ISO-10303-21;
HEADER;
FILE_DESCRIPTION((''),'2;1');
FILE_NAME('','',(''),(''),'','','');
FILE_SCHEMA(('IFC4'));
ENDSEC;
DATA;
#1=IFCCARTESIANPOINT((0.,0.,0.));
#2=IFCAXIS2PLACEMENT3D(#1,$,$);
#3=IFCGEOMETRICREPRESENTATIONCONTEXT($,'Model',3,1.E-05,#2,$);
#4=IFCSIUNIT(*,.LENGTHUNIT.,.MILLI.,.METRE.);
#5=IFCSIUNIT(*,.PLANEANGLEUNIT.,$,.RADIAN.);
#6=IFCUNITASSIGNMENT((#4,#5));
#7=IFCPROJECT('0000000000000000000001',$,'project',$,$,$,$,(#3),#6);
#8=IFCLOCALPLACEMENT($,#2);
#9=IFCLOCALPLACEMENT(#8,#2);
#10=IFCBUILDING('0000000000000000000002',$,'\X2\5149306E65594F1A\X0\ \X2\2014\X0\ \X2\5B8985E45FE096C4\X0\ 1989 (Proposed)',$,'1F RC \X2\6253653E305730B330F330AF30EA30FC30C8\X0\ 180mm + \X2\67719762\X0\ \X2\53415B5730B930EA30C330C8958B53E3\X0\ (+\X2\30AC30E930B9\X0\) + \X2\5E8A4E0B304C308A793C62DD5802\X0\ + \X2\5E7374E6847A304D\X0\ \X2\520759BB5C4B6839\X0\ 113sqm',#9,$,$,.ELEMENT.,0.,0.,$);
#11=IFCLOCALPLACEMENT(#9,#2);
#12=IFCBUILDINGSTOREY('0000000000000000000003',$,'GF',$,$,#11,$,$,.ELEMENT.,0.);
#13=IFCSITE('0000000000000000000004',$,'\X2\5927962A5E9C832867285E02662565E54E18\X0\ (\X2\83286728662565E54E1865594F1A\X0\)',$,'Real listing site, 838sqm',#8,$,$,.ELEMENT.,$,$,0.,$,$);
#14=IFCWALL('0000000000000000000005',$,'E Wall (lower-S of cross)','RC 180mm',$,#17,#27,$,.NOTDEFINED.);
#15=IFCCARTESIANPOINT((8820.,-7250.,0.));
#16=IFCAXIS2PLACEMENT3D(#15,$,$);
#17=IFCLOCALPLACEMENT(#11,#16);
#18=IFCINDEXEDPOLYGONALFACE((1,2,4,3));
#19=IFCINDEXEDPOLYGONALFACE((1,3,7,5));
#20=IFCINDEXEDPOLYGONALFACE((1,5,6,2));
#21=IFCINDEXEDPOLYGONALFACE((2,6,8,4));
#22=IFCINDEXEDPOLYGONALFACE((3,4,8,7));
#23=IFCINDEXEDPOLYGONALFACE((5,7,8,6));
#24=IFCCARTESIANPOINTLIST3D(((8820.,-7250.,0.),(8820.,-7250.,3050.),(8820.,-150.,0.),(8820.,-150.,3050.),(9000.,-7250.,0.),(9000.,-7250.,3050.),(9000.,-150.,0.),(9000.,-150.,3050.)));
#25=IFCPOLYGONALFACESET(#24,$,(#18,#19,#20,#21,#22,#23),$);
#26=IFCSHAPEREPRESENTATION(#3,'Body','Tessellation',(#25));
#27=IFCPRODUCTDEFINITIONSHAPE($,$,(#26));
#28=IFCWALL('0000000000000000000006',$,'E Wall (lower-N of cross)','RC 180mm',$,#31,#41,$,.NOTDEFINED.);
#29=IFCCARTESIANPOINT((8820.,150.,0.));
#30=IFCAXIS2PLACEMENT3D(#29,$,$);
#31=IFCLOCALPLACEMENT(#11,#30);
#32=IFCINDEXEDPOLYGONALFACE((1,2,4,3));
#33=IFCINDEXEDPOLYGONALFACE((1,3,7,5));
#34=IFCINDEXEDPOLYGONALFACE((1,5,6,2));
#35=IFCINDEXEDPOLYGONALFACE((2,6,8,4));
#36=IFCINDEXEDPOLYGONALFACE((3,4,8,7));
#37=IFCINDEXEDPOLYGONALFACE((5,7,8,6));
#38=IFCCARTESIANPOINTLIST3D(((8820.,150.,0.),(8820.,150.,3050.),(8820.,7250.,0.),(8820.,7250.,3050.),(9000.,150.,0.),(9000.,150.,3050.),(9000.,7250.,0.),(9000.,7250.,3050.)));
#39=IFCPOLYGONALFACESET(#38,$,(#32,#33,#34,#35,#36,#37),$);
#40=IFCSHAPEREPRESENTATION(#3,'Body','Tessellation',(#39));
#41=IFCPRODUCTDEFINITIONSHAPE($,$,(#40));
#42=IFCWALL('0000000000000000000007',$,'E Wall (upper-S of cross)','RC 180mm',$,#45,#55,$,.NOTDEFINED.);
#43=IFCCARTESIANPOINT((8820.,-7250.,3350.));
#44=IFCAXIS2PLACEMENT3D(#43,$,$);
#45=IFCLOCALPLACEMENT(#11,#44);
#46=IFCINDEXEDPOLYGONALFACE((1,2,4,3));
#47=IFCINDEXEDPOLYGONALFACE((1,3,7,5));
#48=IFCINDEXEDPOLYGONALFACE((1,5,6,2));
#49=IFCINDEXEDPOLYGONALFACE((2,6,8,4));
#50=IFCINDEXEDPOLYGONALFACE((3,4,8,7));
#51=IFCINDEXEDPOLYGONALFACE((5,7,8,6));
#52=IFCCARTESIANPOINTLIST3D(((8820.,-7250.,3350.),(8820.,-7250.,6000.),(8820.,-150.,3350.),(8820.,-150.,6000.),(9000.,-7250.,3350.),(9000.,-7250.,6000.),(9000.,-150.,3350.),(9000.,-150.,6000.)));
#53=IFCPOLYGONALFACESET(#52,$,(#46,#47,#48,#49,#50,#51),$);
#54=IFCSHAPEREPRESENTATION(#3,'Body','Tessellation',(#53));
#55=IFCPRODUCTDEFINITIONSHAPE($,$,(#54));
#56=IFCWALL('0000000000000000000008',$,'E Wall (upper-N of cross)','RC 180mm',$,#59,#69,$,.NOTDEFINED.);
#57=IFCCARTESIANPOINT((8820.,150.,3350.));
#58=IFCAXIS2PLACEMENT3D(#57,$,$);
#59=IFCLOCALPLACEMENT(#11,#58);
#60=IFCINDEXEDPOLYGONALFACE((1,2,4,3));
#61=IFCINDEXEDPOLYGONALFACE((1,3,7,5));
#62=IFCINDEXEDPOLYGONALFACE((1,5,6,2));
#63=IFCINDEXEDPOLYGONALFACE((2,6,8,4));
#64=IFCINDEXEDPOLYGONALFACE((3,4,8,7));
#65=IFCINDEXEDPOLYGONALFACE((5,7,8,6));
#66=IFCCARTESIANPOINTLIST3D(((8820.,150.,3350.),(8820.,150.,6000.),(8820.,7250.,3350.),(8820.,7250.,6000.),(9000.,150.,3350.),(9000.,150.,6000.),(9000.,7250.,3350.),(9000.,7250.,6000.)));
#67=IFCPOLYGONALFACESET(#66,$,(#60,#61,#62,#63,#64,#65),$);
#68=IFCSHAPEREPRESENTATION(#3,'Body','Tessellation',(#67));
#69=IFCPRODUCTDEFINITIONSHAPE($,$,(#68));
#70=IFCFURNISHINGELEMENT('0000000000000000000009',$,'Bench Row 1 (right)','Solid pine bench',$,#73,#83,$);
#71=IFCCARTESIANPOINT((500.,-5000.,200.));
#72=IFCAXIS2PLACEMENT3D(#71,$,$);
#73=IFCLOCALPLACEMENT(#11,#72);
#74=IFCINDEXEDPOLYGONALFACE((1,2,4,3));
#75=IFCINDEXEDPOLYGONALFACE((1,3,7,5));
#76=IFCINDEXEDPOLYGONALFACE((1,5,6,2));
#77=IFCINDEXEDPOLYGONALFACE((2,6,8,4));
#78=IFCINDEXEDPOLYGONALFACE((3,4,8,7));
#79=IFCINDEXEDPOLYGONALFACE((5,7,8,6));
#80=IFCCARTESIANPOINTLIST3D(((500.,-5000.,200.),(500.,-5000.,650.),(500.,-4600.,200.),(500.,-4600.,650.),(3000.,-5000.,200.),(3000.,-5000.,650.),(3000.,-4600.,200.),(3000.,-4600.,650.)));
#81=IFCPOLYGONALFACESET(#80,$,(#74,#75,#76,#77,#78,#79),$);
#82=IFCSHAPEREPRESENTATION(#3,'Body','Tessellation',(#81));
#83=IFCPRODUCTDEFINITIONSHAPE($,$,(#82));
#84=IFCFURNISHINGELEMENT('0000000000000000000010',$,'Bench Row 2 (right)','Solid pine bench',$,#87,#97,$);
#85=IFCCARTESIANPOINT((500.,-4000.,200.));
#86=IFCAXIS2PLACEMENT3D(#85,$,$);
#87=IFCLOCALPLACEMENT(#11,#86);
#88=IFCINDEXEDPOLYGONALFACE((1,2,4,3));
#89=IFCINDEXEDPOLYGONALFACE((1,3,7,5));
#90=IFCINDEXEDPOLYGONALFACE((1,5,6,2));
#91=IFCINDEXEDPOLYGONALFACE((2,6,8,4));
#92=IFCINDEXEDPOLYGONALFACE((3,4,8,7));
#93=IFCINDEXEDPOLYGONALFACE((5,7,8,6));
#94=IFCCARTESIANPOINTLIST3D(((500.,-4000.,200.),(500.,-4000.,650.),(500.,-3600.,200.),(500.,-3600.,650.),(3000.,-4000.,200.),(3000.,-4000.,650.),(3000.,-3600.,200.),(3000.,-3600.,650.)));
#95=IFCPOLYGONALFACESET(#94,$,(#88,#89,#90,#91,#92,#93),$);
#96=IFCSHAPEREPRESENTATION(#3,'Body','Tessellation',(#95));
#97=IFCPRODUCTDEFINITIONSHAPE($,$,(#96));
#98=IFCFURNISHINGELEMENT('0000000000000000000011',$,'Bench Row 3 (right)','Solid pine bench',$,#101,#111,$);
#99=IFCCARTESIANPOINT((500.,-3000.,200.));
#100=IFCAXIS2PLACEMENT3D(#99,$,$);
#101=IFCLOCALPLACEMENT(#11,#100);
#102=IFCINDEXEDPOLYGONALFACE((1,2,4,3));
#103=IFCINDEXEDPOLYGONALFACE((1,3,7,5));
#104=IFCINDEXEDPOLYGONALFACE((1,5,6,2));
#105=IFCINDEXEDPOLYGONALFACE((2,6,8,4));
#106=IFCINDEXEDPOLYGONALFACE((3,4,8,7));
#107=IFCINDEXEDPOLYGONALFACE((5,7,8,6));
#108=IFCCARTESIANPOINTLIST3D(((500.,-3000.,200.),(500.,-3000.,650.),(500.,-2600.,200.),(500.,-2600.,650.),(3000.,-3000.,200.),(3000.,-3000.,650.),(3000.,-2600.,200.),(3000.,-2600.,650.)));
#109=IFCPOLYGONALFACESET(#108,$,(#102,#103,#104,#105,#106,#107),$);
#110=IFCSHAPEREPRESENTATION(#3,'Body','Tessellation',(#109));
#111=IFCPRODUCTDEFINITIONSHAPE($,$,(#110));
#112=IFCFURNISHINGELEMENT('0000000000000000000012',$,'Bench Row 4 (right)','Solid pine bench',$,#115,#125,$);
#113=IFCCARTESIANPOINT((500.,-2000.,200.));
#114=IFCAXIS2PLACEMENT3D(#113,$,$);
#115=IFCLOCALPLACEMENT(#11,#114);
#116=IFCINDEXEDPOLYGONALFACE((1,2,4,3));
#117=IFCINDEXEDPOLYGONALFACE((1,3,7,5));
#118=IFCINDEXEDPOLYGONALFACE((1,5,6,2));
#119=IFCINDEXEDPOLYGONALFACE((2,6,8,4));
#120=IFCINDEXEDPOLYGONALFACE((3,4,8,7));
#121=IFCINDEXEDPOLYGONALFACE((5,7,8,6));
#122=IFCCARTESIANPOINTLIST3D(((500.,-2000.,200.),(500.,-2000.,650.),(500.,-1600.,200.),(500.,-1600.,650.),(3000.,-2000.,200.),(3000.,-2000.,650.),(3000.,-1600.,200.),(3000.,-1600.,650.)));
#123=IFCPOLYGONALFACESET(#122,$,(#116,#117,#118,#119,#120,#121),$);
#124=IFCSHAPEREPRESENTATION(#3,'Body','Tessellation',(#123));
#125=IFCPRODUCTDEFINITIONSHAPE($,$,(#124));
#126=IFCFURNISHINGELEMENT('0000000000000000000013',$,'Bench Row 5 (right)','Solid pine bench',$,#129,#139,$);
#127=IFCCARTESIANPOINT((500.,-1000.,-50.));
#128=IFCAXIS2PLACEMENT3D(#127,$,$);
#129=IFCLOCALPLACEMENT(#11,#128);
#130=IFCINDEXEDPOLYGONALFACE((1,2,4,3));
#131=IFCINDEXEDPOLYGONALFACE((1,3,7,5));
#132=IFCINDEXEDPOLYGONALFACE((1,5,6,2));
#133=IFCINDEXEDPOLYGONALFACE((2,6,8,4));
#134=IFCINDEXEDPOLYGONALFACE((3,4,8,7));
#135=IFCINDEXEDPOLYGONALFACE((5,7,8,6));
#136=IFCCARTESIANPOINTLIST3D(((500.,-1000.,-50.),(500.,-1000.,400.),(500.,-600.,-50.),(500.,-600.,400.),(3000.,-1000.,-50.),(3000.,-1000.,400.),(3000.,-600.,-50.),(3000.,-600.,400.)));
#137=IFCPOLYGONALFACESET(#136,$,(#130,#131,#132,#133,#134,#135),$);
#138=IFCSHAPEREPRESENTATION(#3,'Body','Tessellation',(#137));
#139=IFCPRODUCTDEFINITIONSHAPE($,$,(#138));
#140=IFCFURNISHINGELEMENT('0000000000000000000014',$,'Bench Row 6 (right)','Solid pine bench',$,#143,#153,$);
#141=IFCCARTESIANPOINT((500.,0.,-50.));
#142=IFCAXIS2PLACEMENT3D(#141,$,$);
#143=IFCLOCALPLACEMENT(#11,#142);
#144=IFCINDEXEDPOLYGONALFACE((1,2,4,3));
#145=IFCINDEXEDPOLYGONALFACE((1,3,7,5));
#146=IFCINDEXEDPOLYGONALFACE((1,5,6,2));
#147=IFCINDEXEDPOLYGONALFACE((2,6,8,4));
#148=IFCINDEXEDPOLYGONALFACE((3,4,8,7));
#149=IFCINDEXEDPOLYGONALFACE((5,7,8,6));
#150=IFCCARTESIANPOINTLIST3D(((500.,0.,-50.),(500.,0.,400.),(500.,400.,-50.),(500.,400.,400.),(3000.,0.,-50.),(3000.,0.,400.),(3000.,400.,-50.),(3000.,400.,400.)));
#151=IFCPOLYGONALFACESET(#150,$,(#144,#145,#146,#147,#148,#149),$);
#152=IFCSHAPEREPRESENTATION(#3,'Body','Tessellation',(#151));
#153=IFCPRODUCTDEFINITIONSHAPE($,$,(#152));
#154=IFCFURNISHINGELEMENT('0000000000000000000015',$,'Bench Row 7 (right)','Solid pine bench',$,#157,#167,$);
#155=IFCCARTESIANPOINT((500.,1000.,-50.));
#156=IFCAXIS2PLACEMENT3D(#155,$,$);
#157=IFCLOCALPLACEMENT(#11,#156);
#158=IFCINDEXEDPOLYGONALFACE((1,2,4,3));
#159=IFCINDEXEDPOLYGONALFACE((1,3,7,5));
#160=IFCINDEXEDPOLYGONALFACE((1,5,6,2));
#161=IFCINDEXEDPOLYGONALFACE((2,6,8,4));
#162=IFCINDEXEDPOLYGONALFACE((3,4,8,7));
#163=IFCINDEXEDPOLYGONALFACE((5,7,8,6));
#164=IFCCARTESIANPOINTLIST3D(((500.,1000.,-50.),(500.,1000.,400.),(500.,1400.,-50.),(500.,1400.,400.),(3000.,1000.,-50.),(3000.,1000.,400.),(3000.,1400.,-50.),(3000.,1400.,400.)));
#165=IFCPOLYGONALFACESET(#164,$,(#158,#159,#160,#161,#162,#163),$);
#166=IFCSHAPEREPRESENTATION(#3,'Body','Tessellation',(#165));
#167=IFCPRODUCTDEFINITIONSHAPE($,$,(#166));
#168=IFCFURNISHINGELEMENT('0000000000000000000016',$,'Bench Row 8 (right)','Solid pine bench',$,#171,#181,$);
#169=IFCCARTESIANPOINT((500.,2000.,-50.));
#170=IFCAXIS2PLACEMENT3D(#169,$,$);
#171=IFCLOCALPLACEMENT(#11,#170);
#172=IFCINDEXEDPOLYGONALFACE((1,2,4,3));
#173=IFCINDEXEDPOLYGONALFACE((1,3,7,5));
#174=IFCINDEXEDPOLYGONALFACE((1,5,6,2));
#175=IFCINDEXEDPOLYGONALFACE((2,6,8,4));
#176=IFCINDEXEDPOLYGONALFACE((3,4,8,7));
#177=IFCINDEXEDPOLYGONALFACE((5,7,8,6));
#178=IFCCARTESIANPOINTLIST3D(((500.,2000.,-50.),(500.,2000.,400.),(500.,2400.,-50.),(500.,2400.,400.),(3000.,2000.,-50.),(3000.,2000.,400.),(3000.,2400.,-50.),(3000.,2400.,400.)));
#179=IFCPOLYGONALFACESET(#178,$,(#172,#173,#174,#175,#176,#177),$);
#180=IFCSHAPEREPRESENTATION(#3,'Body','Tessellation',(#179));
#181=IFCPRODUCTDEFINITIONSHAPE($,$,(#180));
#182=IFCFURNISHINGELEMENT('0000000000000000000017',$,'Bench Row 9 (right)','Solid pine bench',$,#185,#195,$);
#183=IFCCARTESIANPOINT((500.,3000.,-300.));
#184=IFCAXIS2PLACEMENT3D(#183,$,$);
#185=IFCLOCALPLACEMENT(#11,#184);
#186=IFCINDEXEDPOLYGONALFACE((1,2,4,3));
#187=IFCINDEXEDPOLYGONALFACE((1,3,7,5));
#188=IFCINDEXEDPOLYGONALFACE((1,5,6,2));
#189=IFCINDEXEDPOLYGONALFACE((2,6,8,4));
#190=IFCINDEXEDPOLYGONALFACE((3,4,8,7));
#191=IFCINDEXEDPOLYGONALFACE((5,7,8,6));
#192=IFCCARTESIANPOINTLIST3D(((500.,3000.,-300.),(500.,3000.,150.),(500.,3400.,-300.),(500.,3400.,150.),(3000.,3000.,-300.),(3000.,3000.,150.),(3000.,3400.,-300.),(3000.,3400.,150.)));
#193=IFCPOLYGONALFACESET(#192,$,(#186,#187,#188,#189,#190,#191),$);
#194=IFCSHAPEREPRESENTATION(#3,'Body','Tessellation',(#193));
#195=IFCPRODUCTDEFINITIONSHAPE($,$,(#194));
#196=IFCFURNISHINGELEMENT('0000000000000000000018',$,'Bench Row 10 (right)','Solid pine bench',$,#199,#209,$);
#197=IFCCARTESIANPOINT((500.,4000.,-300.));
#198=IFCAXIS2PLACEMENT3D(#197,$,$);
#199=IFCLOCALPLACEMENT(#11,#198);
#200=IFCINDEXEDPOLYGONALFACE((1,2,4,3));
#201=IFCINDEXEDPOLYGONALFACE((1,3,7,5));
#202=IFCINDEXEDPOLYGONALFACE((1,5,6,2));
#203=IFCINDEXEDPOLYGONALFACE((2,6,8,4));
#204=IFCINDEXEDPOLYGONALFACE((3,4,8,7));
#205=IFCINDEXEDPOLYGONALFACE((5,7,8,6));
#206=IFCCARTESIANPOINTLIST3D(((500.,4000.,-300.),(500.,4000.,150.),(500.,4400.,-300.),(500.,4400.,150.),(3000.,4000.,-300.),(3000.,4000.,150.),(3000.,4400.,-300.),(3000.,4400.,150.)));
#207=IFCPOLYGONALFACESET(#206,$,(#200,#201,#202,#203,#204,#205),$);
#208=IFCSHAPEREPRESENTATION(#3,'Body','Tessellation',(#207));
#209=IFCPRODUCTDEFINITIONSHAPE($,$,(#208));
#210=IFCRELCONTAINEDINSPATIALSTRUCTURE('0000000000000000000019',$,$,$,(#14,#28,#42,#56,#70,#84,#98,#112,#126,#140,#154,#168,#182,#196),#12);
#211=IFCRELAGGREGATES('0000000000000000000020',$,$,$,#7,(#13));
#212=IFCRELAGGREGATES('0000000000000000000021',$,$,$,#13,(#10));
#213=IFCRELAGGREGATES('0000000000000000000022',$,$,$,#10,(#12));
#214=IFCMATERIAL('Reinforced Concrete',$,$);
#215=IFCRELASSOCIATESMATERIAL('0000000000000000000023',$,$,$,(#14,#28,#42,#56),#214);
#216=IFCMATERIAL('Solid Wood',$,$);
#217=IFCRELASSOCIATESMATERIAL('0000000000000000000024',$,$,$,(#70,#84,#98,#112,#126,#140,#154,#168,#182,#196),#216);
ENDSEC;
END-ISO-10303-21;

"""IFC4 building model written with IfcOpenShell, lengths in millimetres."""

from ifc_helpers import new_model, si_unit, frame, frame_2d, origin, place, context, project, spatial, rectangle, extrude, material, element, save


model = new_model("IFC4")

# Units and contexts
model_context = context("Model", 3, precision=1e-05, world=origin())
ifc_project = project(units=[si_unit("LENGTHUNIT", "METRE", prefix="MILLI"), si_unit("PLANEANGLEUNIT", "RADIAN")], contexts=[model_context])

# Site, building, storey
site_placement = place(None, origin())
site = spatial("IfcSite", under=ifc_project, at=site_placement, Name="大阪府茨木市春日丘 (茨木春日丘教会)", ObjectType="Real listing site, 838sqm", CompositionType="ELEMENT", RefElevation=0.0)
building_placement = place(site_placement, origin())
building = spatial("IfcBuilding", under=site, at=building_placement, Name="光の教会 — 安藤忠雄 1989 (Proposed)", ObjectType="1F RC 打放しコンクリート 180mm + 東面 十字スリット開口 (+ガラス) + 床下がり礼拝堂 + 平瓦葺き 切妻屋根 113sqm", CompositionType="ELEMENT", ElevationOfRefHeight=0.0, ElevationOfTerrain=0.0)
storey_placement = place(building_placement, origin())
storey = spatial("IfcBuildingStorey", under=building, at=storey_placement, Name="GF", CompositionType="ELEMENT", Elevation=0.0)

# Walls
ifc_material_1 = material(Name="Reinforced Concrete")
wall_1_placement = place(storey_placement, frame((8820.0, -7250.0, 0.0)))
element("IfcWall", 1, at=wall_1_placement, inside=storey, material=ifc_material_1, Name="E Wall (lower-S of cross)", Description="RC 180mm", PredefinedType="NOTDEFINED", context=model_context, shape_type="SweptSolid", body=[
    extrude(rectangle(XDim=180.0, YDim=7100.0, at=frame_2d((90.0, 3550.0))), frame((8820.0, -7250.0, 0.0)), (0.0, 0.0, 1.0), 3050.0),
])
wall_2_placement = place(storey_placement, frame((8820.0, 150.0, 0.0)))
element("IfcWall", 2, at=wall_2_placement, inside=storey, material=ifc_material_1, Name="E Wall (lower-N of cross)", Description="RC 180mm", PredefinedType="NOTDEFINED", context=model_context, shape_type="SweptSolid", body=[
    extrude(rectangle(XDim=180.0, YDim=7100.0, at=frame_2d((90.0, 3550.0))), frame((8820.0, 150.0, 0.0)), (0.0, 0.0, 1.0), 3050.0),
])
wall_3_placement = place(storey_placement, frame((8820.0, -7250.0, 3350.0)))
element("IfcWall", 3, at=wall_3_placement, inside=storey, material=ifc_material_1, Name="E Wall (upper-S of cross)", Description="RC 180mm", PredefinedType="NOTDEFINED", context=model_context, shape_type="SweptSolid", body=[
    extrude(rectangle(XDim=180.0, YDim=7100.0, at=frame_2d((90.0, 3550.0))), frame((8820.0, -7250.0, 3350.0)), (0.0, 0.0, 1.0), 2650.0),
])
wall_4_placement = place(storey_placement, frame((8820.0, 150.0, 3350.0)))
element("IfcWall", 4, at=wall_4_placement, inside=storey, material=ifc_material_1, Name="E Wall (upper-N of cross)", Description="RC 180mm", PredefinedType="NOTDEFINED", context=model_context, shape_type="SweptSolid", body=[
    extrude(rectangle(XDim=180.0, YDim=7100.0, at=frame_2d((90.0, 3550.0))), frame((8820.0, 150.0, 3350.0)), (0.0, 0.0, 1.0), 2650.0),
])

# Furnishing elements
ifc_material_2 = material(Name="Solid Wood")
furnishing_1_placement = place(storey_placement, frame((500.0, -5000.0, 200.0)))
element("IfcFurnishingElement", 5, at=furnishing_1_placement, inside=storey, material=ifc_material_2, Name="Bench Row 1 (right)", Description="Solid pine bench", context=model_context, shape_type="SweptSolid", body=[
    extrude(rectangle(XDim=2500.0, YDim=400.0, at=frame_2d((1250.0, 200.0))), frame((500.0, -5000.0, 200.0)), (0.0, 0.0, 1.0), 450.0),
])
furnishing_2_placement = place(storey_placement, frame((500.0, -4000.0, 200.0)))
element("IfcFurnishingElement", 6, at=furnishing_2_placement, inside=storey, material=ifc_material_2, Name="Bench Row 2 (right)", Description="Solid pine bench", context=model_context, shape_type="SweptSolid", body=[
    extrude(rectangle(XDim=2500.0, YDim=400.0, at=frame_2d((1250.0, 200.0))), frame((500.0, -4000.0, 200.0)), (0.0, 0.0, 1.0), 450.0),
])
furnishing_3_placement = place(storey_placement, frame((500.0, -3000.0, 200.0)))
element("IfcFurnishingElement", 7, at=furnishing_3_placement, inside=storey, material=ifc_material_2, Name="Bench Row 3 (right)", Description="Solid pine bench", context=model_context, shape_type="SweptSolid", body=[
    extrude(rectangle(XDim=2500.0, YDim=400.0, at=frame_2d((1250.0, 200.0))), frame((500.0, -3000.0, 200.0)), (0.0, 0.0, 1.0), 450.0),
])
furnishing_4_placement = place(storey_placement, frame((500.0, -2000.0, 200.0)))
element("IfcFurnishingElement", 8, at=furnishing_4_placement, inside=storey, material=ifc_material_2, Name="Bench Row 4 (right)", Description="Solid pine bench", context=model_context, shape_type="SweptSolid", body=[
    extrude(rectangle(XDim=2500.0, YDim=400.0, at=frame_2d((1250.0, 200.0))), frame((500.0, -2000.0, 200.0)), (0.0, 0.0, 1.0), 450.0),
])
furnishing_5_placement = place(storey_placement, frame((500.0, -1000.0, -50.0)))
element("IfcFurnishingElement", 9, at=furnishing_5_placement, inside=storey, material=ifc_material_2, Name="Bench Row 5 (right)", Description="Solid pine bench", context=model_context, shape_type="SweptSolid", body=[
    extrude(rectangle(XDim=2500.0, YDim=400.0, at=frame_2d((1250.0, 200.0))), frame((500.0, -1000.0, -50.0)), (0.0, 0.0, 1.0), 450.0),
])
furnishing_6_placement = place(storey_placement, frame((500.0, 0.0, -50.0)))
element("IfcFurnishingElement", 10, at=furnishing_6_placement, inside=storey, material=ifc_material_2, Name="Bench Row 6 (right)", Description="Solid pine bench", context=model_context, shape_type="SweptSolid", body=[
    extrude(rectangle(XDim=2500.0, YDim=400.0, at=frame_2d((1250.0, 200.0))), frame((500.0, 0.0, -50.0)), (0.0, 0.0, 1.0), 450.0),
])
furnishing_7_placement = place(storey_placement, frame((500.0, 1000.0, -50.0)))
element("IfcFurnishingElement", 11, at=furnishing_7_placement, inside=storey, material=ifc_material_2, Name="Bench Row 7 (right)", Description="Solid pine bench", context=model_context, shape_type="SweptSolid", body=[
    extrude(rectangle(XDim=2500.0, YDim=400.0, at=frame_2d((1250.0, 200.0))), frame((500.0, 1000.0, -50.0)), (0.0, 0.0, 1.0), 450.0),
])
furnishing_8_placement = place(storey_placement, frame((500.0, 2000.0, -50.0)))
element("IfcFurnishingElement", 12, at=furnishing_8_placement, inside=storey, material=ifc_material_2, Name="Bench Row 8 (right)", Description="Solid pine bench", context=model_context, shape_type="SweptSolid", body=[
    extrude(rectangle(XDim=2500.0, YDim=400.0, at=frame_2d((1250.0, 200.0))), frame((500.0, 2000.0, -50.0)), (0.0, 0.0, 1.0), 450.0),
])
furnishing_9_placement = place(storey_placement, frame((500.0, 3000.0, -300.0)))
element("IfcFurnishingElement", 13, at=furnishing_9_placement, inside=storey, material=ifc_material_2, Name="Bench Row 9 (right)", Description="Solid pine bench", context=model_context, shape_type="SweptSolid", body=[
    extrude(rectangle(XDim=2500.0, YDim=400.0, at=frame_2d((1250.0, 200.0))), frame((500.0, 3000.0, -300.0)), (0.0, 0.0, 1.0), 450.0),
])
furnishing_10_placement = place(storey_placement, frame((500.0, 4000.0, -300.0)))
element("IfcFurnishingElement", 14, at=furnishing_10_placement, inside=storey, material=ifc_material_2, Name="Bench Row 10 (right)", Description="Solid pine bench", context=model_context, shape_type="SweptSolid", body=[
    extrude(rectangle(XDim=2500.0, YDim=400.0, at=frame_2d((1250.0, 200.0))), frame((500.0, 4000.0, -300.0)), (0.0, 0.0, 1.0), 450.0),
])

save(model, "model.ifc")
